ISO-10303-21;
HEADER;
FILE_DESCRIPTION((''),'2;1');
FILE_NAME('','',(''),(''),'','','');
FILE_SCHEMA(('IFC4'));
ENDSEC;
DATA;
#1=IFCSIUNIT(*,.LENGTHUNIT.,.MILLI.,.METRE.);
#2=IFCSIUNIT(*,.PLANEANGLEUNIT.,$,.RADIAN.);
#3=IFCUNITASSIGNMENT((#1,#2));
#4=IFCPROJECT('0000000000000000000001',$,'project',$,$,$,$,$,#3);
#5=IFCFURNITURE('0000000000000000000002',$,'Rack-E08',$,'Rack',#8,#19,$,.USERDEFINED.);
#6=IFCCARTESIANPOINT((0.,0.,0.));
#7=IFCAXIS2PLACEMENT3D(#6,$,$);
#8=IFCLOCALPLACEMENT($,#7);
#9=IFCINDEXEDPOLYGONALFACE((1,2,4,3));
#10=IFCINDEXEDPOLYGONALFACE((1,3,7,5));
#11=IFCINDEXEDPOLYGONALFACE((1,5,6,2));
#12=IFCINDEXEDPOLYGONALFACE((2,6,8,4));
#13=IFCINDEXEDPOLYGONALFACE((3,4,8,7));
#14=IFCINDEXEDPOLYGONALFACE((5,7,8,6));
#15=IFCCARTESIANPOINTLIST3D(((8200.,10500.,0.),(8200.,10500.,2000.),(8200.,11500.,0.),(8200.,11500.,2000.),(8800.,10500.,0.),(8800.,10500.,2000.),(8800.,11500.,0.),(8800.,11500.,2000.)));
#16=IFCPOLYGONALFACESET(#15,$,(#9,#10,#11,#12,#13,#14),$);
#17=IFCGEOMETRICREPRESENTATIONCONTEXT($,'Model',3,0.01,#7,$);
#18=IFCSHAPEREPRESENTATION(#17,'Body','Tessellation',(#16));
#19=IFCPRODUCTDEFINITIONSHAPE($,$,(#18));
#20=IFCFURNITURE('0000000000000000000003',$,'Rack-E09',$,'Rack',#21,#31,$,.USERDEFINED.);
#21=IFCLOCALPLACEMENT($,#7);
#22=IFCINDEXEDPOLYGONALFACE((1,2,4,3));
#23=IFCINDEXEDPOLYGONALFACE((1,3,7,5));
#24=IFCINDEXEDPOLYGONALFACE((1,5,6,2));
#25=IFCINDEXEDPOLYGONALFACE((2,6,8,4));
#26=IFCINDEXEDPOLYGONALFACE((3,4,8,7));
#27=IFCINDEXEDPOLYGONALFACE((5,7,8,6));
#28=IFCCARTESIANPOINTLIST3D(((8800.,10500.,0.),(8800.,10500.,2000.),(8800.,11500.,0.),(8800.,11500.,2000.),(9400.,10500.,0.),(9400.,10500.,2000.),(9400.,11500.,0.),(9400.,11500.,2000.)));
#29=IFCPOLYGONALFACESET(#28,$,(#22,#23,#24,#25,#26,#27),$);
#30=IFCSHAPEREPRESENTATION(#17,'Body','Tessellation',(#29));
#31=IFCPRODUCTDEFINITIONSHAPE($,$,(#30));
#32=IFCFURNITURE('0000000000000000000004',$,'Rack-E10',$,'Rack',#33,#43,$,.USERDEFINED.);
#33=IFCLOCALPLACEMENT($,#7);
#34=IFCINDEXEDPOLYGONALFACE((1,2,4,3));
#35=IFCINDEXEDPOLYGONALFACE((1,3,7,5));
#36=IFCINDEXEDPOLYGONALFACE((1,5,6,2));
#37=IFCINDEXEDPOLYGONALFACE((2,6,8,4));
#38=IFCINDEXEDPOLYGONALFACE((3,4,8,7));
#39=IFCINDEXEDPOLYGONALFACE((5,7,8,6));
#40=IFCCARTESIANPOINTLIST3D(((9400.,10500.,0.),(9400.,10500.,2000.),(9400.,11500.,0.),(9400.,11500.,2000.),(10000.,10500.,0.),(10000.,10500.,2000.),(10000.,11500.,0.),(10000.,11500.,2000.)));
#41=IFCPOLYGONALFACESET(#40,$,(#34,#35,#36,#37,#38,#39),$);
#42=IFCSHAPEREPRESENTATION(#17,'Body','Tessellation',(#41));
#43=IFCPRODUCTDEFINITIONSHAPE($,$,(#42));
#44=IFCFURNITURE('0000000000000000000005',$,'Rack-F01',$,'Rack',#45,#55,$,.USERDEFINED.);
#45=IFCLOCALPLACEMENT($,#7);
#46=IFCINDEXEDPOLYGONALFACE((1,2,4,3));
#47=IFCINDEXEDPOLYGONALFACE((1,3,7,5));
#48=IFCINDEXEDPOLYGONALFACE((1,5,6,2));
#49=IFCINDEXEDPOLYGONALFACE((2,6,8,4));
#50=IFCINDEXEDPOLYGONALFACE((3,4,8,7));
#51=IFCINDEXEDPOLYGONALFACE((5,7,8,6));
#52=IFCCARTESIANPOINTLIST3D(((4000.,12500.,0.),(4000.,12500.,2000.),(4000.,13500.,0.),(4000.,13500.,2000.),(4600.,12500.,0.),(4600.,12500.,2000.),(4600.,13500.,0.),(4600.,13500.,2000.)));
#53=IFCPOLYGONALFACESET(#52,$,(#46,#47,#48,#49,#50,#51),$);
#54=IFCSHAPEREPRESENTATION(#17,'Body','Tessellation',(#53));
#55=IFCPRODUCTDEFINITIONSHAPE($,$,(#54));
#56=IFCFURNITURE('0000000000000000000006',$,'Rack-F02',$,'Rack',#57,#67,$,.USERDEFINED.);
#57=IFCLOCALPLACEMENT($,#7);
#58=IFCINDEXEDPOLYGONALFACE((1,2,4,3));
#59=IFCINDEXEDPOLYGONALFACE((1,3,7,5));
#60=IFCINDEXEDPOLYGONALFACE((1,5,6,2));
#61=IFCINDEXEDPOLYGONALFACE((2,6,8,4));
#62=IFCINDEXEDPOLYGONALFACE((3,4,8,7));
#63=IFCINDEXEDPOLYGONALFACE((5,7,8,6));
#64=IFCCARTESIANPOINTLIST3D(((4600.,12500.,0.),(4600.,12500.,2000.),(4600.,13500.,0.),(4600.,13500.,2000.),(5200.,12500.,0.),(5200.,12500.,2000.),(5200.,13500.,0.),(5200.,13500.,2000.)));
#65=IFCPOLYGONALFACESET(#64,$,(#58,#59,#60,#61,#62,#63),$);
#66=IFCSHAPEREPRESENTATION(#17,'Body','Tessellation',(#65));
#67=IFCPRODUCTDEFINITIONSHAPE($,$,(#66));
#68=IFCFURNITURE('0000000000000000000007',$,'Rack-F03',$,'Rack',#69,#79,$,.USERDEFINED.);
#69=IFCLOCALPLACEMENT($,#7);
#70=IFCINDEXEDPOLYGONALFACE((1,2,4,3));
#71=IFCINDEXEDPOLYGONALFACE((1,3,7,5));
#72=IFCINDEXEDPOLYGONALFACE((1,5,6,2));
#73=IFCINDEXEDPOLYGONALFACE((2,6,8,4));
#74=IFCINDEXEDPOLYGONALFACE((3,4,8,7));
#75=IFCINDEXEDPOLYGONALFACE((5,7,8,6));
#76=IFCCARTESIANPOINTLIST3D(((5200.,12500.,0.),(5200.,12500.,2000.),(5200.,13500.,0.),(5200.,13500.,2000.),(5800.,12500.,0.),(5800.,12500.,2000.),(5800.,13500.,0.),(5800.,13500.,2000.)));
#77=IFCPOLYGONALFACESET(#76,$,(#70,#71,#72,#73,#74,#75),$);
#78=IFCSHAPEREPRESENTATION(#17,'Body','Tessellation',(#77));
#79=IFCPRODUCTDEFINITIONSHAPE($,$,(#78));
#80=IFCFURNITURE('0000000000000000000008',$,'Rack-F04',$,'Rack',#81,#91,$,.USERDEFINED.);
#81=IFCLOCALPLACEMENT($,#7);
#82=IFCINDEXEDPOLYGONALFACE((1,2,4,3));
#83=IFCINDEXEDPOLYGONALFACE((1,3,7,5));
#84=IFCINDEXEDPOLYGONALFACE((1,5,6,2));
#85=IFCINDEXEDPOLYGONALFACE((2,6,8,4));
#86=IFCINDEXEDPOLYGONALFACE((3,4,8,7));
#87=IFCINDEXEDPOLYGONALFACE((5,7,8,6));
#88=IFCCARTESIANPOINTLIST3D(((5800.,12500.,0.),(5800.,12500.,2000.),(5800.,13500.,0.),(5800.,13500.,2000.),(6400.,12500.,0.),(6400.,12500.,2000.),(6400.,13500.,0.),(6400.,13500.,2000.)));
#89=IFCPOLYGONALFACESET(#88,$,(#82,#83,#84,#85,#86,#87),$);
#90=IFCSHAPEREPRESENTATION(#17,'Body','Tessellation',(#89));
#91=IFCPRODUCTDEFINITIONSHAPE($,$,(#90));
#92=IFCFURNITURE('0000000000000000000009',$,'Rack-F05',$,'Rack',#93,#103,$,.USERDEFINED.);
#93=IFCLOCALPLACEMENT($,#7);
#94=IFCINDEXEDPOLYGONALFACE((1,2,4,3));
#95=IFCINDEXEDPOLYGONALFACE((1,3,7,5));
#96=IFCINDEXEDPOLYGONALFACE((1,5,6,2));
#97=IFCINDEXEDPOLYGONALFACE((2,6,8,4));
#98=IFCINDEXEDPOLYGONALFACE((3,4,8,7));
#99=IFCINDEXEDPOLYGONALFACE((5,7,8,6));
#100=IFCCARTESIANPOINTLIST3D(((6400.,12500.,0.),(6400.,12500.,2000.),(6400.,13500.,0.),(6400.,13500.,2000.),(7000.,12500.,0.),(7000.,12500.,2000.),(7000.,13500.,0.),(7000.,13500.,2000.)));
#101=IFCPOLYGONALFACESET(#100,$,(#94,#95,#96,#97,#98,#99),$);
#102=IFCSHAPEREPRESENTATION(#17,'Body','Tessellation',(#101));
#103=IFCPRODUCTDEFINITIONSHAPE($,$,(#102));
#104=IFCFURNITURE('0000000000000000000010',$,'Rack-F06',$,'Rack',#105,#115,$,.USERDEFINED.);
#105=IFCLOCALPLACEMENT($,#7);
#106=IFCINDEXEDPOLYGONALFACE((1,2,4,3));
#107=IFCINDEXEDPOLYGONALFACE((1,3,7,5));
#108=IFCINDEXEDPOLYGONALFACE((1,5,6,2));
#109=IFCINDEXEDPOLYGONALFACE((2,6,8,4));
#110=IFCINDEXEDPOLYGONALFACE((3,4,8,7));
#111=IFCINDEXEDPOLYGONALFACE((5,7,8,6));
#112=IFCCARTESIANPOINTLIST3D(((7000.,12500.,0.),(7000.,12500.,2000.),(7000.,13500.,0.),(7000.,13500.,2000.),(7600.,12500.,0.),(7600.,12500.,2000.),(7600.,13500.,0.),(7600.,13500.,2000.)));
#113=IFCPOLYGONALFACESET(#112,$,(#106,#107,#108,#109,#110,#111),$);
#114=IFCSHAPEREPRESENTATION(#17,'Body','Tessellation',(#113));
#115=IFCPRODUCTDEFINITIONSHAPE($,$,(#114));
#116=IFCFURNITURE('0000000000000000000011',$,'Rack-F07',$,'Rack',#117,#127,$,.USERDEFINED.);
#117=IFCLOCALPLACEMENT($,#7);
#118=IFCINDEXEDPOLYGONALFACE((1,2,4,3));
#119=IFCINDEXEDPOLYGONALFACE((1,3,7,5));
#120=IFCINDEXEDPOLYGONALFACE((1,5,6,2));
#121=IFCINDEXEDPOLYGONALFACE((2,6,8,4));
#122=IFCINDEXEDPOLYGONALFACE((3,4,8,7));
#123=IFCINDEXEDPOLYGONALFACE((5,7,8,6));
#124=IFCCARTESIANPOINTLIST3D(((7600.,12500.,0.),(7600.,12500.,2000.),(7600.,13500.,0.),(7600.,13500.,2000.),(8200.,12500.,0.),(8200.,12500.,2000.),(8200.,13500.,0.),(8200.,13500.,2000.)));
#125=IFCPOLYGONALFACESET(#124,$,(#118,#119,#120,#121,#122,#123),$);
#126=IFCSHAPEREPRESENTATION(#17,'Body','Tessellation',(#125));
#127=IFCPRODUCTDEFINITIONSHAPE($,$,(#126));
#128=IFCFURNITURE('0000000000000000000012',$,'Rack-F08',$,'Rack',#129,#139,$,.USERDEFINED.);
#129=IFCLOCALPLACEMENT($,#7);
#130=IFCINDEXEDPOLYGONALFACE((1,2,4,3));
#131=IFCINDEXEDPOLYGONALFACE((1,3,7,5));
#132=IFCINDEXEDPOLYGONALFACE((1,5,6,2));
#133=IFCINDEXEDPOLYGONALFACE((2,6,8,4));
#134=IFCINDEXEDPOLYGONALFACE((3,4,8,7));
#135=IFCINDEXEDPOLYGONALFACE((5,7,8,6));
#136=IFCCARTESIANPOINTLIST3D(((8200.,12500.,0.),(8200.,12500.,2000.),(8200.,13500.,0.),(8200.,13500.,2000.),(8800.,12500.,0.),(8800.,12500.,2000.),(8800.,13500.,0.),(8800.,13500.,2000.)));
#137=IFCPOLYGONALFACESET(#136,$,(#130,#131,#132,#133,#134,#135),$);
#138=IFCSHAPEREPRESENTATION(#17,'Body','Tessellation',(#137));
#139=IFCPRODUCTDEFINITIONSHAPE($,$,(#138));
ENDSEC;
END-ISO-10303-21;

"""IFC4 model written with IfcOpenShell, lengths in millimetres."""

from ifc_helpers import new_model, si_unit, frame, origin, place, context, project, polyline, outline, extrude, element, save


model = new_model("IFC4")

# Units and contexts
model_context = context("Model", 3, precision=0.01, world=origin())
ifc_project = project(units=[si_unit("LENGTHUNIT", "METRE", prefix="MILLI"), si_unit("PLANEANGLEUNIT", "RADIAN")])

# Furniture
for number, where, name in (
    (1, (8500.0, 11000.0, 0.0), "Rack-E08"),
    (2, (9100.0, 11000.0, 0.0), "Rack-E09"),
    (3, (9700.0, 11000.0, 0.0), "Rack-E10"),
    (4, (4300.0, 13000.0, 0.0), "Rack-F01"),
    (5, (4900.0, 13000.0, 0.0), "Rack-F02"),
    (6, (5500.0, 13000.0, 0.0), "Rack-F03"),
    (7, (6100.0, 13000.0, 0.0), "Rack-F04"),
    (8, (6700.0, 13000.0, 0.0), "Rack-F05"),
    (9, (7300.0, 13000.0, 0.0), "Rack-F06"),
    (10, (7900.0, 13000.0, 0.0), "Rack-F07"),
    (11, (8500.0, 13000.0, 0.0), "Rack-F08"),
):
    element("IfcFurniture", number, at=place(None, frame(where)), Name=name, ObjectType="Rack", PredefinedType="USERDEFINED", context=model_context, shape_type="SweptSolid", body=[
        extrude(outline(polyline([(-300.0, -500.0), (300.0, -500.0), (300.0, 500.0), (-300.0, 500.0), (-300.0, -500.0)])), origin(), (0.0, 0.0, 1.0), 2000.0),
    ])

save(model, "model.ifc")
